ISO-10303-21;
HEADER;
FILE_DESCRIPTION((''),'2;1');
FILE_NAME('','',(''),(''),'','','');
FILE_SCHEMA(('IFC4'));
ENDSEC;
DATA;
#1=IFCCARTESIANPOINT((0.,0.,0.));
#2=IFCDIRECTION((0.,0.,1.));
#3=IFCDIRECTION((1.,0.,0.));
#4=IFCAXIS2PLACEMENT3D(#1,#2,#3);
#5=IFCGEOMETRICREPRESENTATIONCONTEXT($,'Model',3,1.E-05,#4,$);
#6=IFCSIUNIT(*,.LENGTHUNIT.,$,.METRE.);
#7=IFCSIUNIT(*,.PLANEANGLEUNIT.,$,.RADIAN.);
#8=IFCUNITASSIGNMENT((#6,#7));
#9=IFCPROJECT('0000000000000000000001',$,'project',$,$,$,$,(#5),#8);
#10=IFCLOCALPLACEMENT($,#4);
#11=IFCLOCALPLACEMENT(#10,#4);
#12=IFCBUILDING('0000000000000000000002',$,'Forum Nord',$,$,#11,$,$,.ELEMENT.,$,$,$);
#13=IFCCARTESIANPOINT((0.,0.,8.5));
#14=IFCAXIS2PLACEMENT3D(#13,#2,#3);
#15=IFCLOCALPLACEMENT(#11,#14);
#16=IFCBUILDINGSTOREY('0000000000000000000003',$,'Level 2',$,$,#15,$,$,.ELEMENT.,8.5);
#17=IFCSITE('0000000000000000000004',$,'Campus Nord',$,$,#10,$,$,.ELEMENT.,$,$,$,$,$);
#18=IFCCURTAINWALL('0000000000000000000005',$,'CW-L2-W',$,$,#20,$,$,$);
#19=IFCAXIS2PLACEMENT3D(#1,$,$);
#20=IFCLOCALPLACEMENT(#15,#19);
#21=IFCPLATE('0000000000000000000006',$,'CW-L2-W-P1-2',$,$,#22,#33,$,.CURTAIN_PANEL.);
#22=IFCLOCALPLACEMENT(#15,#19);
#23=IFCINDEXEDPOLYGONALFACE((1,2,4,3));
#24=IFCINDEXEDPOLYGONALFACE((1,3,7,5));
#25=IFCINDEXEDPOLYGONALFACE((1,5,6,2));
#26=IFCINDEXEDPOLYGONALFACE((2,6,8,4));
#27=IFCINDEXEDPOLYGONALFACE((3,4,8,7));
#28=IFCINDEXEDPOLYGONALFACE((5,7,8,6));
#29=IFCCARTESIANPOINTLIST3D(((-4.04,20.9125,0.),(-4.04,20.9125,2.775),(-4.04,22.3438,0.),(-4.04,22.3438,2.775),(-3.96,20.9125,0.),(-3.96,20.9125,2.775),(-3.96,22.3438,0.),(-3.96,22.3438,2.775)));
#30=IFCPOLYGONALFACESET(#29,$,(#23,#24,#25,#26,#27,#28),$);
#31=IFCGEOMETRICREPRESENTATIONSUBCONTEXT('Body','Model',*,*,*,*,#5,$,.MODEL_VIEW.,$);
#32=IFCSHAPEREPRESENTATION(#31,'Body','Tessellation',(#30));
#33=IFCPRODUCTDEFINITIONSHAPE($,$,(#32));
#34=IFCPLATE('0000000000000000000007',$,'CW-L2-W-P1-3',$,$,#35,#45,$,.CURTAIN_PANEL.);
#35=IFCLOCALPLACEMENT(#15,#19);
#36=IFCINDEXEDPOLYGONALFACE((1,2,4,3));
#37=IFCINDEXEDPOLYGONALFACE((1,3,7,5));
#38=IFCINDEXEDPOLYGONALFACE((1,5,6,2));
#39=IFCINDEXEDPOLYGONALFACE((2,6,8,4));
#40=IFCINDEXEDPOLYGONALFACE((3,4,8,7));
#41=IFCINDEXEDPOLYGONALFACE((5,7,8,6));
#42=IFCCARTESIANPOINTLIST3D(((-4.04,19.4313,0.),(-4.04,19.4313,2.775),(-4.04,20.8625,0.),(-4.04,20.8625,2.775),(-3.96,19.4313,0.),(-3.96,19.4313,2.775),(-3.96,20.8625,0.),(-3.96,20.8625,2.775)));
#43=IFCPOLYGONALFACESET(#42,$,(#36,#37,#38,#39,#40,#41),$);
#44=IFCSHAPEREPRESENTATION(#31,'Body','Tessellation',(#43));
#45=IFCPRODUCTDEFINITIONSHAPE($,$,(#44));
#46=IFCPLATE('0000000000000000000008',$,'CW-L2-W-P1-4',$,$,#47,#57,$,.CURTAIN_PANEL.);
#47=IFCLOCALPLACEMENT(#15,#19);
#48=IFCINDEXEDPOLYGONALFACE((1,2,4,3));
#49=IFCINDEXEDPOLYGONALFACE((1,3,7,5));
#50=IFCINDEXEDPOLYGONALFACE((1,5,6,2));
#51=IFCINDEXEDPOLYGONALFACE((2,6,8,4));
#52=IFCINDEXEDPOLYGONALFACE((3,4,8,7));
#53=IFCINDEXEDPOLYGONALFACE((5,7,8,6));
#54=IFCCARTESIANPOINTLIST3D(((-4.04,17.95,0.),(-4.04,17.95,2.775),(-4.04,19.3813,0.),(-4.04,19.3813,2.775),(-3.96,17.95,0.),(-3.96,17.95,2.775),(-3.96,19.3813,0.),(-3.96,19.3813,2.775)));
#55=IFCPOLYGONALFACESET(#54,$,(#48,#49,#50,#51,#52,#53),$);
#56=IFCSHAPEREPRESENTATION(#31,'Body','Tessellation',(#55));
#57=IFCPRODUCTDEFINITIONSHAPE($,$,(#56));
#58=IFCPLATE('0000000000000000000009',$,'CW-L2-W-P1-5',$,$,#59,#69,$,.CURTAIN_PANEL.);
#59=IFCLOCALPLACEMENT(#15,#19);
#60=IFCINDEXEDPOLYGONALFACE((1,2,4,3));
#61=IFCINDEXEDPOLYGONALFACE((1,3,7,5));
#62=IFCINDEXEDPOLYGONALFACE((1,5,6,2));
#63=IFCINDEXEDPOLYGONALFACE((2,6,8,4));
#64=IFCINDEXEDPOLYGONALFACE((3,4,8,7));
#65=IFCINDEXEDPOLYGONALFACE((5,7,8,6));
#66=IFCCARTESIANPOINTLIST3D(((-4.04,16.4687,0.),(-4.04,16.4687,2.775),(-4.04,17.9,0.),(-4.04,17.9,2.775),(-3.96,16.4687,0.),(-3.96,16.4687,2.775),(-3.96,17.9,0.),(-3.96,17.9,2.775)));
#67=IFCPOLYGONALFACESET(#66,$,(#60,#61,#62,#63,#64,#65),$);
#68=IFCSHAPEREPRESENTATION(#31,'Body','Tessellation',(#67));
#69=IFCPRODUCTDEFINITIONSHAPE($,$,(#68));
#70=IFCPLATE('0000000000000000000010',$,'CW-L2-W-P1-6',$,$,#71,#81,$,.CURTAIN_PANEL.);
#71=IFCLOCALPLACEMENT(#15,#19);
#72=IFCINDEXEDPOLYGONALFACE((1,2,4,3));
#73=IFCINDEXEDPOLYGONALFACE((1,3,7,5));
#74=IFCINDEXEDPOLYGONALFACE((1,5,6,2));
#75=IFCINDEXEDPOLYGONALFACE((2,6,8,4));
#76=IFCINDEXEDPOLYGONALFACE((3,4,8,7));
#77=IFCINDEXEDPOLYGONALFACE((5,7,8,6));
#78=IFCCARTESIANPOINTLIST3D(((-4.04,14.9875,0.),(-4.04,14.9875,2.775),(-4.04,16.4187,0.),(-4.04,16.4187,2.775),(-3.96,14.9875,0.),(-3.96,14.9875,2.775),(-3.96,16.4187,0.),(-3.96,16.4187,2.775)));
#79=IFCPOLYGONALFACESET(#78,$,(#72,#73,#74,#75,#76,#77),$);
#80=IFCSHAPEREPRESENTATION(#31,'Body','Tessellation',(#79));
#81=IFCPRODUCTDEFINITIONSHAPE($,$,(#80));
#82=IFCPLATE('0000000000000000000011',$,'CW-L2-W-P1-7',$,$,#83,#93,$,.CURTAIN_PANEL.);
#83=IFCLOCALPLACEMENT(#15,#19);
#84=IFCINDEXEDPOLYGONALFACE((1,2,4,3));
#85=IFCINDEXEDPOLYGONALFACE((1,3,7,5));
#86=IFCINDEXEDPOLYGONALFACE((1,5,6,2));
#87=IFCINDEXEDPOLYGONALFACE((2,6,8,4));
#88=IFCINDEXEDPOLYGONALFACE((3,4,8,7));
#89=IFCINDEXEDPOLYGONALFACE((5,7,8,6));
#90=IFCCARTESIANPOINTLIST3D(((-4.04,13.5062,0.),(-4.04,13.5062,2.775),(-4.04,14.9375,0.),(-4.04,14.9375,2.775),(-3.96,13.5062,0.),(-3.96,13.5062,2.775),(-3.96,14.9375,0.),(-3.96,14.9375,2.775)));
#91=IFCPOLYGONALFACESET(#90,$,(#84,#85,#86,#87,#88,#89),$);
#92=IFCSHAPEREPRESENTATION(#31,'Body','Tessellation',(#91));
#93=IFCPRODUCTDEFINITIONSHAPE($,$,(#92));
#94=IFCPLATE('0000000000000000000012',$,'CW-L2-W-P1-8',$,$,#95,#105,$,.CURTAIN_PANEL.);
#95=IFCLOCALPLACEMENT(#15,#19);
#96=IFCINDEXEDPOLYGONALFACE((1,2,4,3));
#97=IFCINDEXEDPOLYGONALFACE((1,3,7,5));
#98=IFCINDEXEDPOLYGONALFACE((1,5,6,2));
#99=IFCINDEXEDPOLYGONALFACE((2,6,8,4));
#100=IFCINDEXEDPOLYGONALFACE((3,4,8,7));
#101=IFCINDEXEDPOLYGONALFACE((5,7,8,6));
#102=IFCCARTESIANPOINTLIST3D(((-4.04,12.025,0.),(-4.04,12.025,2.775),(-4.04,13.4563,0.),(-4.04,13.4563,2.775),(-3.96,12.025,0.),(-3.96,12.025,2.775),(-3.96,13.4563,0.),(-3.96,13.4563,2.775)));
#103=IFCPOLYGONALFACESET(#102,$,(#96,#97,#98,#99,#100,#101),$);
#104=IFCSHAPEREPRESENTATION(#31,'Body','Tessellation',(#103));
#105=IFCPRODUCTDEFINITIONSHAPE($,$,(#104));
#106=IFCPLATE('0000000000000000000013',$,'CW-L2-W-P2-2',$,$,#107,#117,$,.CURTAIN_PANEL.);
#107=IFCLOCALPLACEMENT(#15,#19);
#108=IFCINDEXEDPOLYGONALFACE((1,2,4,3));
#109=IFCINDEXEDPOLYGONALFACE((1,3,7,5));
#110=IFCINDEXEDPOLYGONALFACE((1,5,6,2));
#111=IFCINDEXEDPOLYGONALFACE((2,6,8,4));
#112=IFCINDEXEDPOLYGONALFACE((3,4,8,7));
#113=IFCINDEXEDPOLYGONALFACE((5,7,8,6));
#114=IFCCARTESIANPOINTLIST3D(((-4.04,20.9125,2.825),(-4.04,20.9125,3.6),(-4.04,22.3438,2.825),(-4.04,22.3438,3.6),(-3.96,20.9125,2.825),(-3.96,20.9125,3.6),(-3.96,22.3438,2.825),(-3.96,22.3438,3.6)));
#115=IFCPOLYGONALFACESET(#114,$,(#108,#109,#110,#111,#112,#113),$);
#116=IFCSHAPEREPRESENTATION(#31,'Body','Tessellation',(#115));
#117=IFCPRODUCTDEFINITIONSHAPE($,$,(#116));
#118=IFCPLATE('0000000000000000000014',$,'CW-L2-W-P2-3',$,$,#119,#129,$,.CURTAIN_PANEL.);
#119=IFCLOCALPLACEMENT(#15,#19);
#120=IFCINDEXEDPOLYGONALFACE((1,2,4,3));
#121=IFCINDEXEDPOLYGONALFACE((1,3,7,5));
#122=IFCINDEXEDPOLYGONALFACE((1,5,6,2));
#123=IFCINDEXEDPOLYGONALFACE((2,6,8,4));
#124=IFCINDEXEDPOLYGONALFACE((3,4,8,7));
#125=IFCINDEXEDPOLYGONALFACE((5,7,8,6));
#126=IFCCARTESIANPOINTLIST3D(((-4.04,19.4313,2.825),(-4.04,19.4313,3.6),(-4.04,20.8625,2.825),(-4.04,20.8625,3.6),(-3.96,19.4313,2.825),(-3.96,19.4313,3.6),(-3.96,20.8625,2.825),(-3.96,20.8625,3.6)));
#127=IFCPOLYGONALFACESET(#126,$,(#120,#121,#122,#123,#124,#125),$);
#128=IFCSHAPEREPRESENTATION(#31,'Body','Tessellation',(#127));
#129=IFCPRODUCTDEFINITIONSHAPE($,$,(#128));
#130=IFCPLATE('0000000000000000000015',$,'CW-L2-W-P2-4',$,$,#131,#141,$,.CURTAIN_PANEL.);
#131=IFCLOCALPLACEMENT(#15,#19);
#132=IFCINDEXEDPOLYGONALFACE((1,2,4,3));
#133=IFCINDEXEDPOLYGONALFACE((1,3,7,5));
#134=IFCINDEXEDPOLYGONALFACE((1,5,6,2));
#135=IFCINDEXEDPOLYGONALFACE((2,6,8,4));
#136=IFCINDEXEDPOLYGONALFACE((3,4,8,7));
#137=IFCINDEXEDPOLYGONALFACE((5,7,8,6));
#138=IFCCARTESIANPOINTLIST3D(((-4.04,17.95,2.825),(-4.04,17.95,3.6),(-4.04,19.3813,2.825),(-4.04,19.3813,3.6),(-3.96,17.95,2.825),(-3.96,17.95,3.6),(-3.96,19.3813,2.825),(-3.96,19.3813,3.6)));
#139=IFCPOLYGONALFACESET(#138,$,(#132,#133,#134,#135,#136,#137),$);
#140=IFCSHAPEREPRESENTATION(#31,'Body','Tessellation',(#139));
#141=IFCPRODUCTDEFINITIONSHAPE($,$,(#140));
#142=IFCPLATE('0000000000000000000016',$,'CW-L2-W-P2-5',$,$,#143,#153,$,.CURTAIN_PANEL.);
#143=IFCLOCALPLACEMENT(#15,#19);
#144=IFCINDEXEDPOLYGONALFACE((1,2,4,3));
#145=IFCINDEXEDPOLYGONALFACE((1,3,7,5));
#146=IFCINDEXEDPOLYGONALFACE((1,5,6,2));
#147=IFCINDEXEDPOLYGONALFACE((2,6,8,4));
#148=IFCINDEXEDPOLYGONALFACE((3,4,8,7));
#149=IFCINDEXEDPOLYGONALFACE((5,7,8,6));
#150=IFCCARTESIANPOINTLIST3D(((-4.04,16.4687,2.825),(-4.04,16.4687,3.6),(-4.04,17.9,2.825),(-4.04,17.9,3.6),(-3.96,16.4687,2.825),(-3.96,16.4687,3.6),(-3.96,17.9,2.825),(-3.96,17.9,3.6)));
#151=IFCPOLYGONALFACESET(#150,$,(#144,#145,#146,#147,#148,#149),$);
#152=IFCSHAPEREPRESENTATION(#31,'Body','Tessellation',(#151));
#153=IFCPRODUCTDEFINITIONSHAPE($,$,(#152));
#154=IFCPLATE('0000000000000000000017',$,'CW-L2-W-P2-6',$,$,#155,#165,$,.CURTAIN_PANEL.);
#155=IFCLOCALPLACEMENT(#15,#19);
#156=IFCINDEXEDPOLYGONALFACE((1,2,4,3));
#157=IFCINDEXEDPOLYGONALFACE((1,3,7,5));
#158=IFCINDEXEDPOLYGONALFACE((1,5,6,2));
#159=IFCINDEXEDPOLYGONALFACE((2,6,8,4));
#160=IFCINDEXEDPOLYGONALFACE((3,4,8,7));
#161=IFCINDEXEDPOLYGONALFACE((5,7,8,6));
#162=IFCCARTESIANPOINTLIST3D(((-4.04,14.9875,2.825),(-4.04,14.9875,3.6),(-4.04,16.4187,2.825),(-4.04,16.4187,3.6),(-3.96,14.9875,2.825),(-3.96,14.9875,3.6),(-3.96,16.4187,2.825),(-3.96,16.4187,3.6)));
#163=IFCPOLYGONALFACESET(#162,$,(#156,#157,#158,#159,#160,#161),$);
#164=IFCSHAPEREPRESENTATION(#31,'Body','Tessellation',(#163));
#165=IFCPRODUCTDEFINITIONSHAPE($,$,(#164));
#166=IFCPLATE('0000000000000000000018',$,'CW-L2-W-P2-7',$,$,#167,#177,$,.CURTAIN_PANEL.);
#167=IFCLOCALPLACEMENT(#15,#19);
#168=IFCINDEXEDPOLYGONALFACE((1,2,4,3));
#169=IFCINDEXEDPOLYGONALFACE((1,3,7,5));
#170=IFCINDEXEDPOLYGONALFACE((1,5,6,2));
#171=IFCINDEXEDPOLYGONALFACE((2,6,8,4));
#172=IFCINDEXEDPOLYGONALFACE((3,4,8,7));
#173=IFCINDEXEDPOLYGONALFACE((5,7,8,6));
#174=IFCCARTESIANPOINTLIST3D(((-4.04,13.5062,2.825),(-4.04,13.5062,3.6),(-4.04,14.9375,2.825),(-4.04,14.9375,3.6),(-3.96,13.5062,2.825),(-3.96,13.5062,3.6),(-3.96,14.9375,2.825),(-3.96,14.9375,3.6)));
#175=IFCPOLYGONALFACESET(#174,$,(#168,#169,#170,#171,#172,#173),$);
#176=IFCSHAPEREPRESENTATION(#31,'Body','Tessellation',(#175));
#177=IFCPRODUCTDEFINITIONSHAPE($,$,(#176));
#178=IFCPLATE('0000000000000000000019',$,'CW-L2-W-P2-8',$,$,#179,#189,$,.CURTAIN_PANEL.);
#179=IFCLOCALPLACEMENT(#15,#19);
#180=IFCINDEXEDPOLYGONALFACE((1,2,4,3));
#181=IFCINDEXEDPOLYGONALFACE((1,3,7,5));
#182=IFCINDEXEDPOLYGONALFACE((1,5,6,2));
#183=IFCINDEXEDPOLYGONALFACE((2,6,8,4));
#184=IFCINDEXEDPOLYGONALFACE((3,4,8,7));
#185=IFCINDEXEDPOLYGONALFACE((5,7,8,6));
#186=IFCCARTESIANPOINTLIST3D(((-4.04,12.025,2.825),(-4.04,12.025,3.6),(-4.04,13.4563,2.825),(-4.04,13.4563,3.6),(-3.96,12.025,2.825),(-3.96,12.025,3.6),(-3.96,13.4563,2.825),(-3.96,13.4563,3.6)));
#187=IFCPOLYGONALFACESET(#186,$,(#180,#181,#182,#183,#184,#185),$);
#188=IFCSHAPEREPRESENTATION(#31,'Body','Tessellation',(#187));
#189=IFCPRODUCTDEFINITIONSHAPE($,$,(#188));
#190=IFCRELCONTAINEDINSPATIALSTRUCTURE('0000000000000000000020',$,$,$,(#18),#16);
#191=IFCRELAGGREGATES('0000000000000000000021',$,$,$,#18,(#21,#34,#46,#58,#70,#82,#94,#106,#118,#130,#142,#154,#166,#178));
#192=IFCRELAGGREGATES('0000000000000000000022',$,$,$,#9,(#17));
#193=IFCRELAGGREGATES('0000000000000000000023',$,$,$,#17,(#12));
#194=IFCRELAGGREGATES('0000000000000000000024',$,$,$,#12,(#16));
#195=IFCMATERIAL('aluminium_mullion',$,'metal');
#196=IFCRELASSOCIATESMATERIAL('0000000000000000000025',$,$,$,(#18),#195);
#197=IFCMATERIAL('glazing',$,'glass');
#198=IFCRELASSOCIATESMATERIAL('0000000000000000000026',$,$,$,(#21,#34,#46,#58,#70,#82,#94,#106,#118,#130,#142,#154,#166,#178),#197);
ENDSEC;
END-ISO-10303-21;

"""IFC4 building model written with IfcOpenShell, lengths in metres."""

from ifc_helpers import new_model, si_unit, frame, frame_2d, origin_with_axes, place, context, subcontext, project, spatial, rectangle, extrude, material, element, aggregate, save


model = new_model("IFC4")

# Units and contexts
model_context = context("Model", 3, precision=1e-05, world=origin_with_axes())
body_context = subcontext(model_context, "Body", "Model", "MODEL_VIEW")
ifc_project = project(units=[si_unit("LENGTHUNIT", "METRE"), si_unit("PLANEANGLEUNIT", "RADIAN")], contexts=[model_context])

# Site, building, storey
site_placement = place(None, origin_with_axes())
site = spatial("IfcSite", under=ifc_project, at=site_placement, Name="Campus Nord", CompositionType="ELEMENT")
building_placement = place(site_placement, origin_with_axes())
building = spatial("IfcBuilding", under=site, at=building_placement, Name="Forum Nord", CompositionType="ELEMENT")
storey_placement = place(building_placement, frame((0.0, 0.0, 8.5), z_axis=(0.0, 0.0, 1.0), x_axis=(1.0, 0.0, 0.0)))
storey = spatial("IfcBuildingStorey", under=building, at=storey_placement, Name="Level 2", CompositionType="ELEMENT", Elevation=8.5)

# Curtain wall, plates
ifc_material_1 = material(Name="aluminium_mullion", Category="metal")
curtain_wall_placement = place(storey_placement, origin_with_axes())
curtain_wall = element("IfcCurtainWall", 1, at=curtain_wall_placement, inside=storey, material=ifc_material_1, Name="CW-L2-W")
ifc_material_2 = material(Name="glazing", Category="glass")
plate_1_placement = place(storey_placement, frame((-4.0, 22.3438, 0.0), z_axis=(0.0, 0.0, 1.0), x_axis=(0.0, -1.0, 0.0)))
plate_1 = element("IfcPlate", 2, at=plate_1_placement, material=ifc_material_2, Name="CW-L2-W-P1-2", PredefinedType="CURTAIN_PANEL", context=body_context, shape_type="SweptSolid", body=[
    extrude(rectangle(XDim=1.4312, YDim=0.08, at=frame_2d((0.7156, 0.0), x_axis=(1.0, 0.0))), origin_with_axes(), (0.0, 0.0, 1.0), 2.775),
])
plate_2_placement = place(storey_placement, frame((-4.0, 20.8625, 0.0), z_axis=(0.0, 0.0, 1.0), x_axis=(0.0, -1.0, 0.0)))
plate_2 = element("IfcPlate", 3, at=plate_2_placement, material=ifc_material_2, Name="CW-L2-W-P1-3", PredefinedType="CURTAIN_PANEL", context=body_context, shape_type="SweptSolid", body=[
    extrude(rectangle(XDim=1.4312, YDim=0.08, at=frame_2d((0.7156, 0.0), x_axis=(1.0, 0.0))), origin_with_axes(), (0.0, 0.0, 1.0), 2.775),
])
plate_3_placement = place(storey_placement, frame((-4.0, 19.3813, 0.0), z_axis=(0.0, 0.0, 1.0), x_axis=(0.0, -1.0, 0.0)))
plate_3 = element("IfcPlate", 4, at=plate_3_placement, material=ifc_material_2, Name="CW-L2-W-P1-4", PredefinedType="CURTAIN_PANEL", context=body_context, shape_type="SweptSolid", body=[
    extrude(rectangle(XDim=1.4312, YDim=0.08, at=frame_2d((0.7156, 0.0), x_axis=(1.0, 0.0))), origin_with_axes(), (0.0, 0.0, 1.0), 2.775),
])
plate_4_placement = place(storey_placement, frame((-4.0, 17.9, 0.0), z_axis=(0.0, 0.0, 1.0), x_axis=(0.0, -1.0, 0.0)))
plate_4 = element("IfcPlate", 5, at=plate_4_placement, material=ifc_material_2, Name="CW-L2-W-P1-5", PredefinedType="CURTAIN_PANEL", context=body_context, shape_type="SweptSolid", body=[
    extrude(rectangle(XDim=1.4312, YDim=0.08, at=frame_2d((0.7156, 0.0), x_axis=(1.0, 0.0))), origin_with_axes(), (0.0, 0.0, 1.0), 2.775),
])
plate_5_placement = place(storey_placement, frame((-4.0, 16.4187, 0.0), z_axis=(0.0, 0.0, 1.0), x_axis=(0.0, -1.0, 0.0)))
plate_5 = element("IfcPlate", 6, at=plate_5_placement, material=ifc_material_2, Name="CW-L2-W-P1-6", PredefinedType="CURTAIN_PANEL", context=body_context, shape_type="SweptSolid", body=[
    extrude(rectangle(XDim=1.4312, YDim=0.08, at=frame_2d((0.7156, 0.0), x_axis=(1.0, 0.0))), origin_with_axes(), (0.0, 0.0, 1.0), 2.775),
])
plate_6_placement = place(storey_placement, frame((-4.0, 14.9375, 0.0), z_axis=(0.0, 0.0, 1.0), x_axis=(0.0, -1.0, 0.0)))
plate_6 = element("IfcPlate", 7, at=plate_6_placement, material=ifc_material_2, Name="CW-L2-W-P1-7", PredefinedType="CURTAIN_PANEL", context=body_context, shape_type="SweptSolid", body=[
    extrude(rectangle(XDim=1.4312, YDim=0.08, at=frame_2d((0.7156, 0.0), x_axis=(1.0, 0.0))), origin_with_axes(), (0.0, 0.0, 1.0), 2.775),
])
plate_7_placement = place(storey_placement, frame((-4.0, 13.4563, 0.0), z_axis=(0.0, 0.0, 1.0), x_axis=(0.0, -1.0, 0.0)))
plate_7 = element("IfcPlate", 8, at=plate_7_placement, material=ifc_material_2, Name="CW-L2-W-P1-8", PredefinedType="CURTAIN_PANEL", context=body_context, shape_type="SweptSolid", body=[
    extrude(rectangle(XDim=1.4312, YDim=0.08, at=frame_2d((0.7156, 0.0), x_axis=(1.0, 0.0))), origin_with_axes(), (0.0, 0.0, 1.0), 2.775),
])
plate_8_placement = place(storey_placement, frame((-4.0, 22.3438, 2.825), z_axis=(0.0, 0.0, 1.0), x_axis=(0.0, -1.0, 0.0)))
plate_8 = element("IfcPlate", 9, at=plate_8_placement, material=ifc_material_2, Name="CW-L2-W-P2-2", PredefinedType="CURTAIN_PANEL", context=body_context, shape_type="SweptSolid", body=[
    extrude(rectangle(XDim=1.4312, YDim=0.08, at=frame_2d((0.7156, 0.0), x_axis=(1.0, 0.0))), origin_with_axes(), (0.0, 0.0, 1.0), 0.775),
])
plate_9_placement = place(storey_placement, frame((-4.0, 20.8625, 2.825), z_axis=(0.0, 0.0, 1.0), x_axis=(0.0, -1.0, 0.0)))
plate_9 = element("IfcPlate", 10, at=plate_9_placement, material=ifc_material_2, Name="CW-L2-W-P2-3", PredefinedType="CURTAIN_PANEL", context=body_context, shape_type="SweptSolid", body=[
    extrude(rectangle(XDim=1.4312, YDim=0.08, at=frame_2d((0.7156, 0.0), x_axis=(1.0, 0.0))), origin_with_axes(), (0.0, 0.0, 1.0), 0.775),
])
plate_10_placement = place(storey_placement, frame((-4.0, 19.3813, 2.825), z_axis=(0.0, 0.0, 1.0), x_axis=(0.0, -1.0, 0.0)))
plate_10 = element("IfcPlate", 11, at=plate_10_placement, material=ifc_material_2, Name="CW-L2-W-P2-4", PredefinedType="CURTAIN_PANEL", context=body_context, shape_type="SweptSolid", body=[
    extrude(rectangle(XDim=1.4312, YDim=0.08, at=frame_2d((0.7156, 0.0), x_axis=(1.0, 0.0))), origin_with_axes(), (0.0, 0.0, 1.0), 0.775),
])
plate_11_placement = place(storey_placement, frame((-4.0, 17.9, 2.825), z_axis=(0.0, 0.0, 1.0), x_axis=(0.0, -1.0, 0.0)))
plate_11 = element("IfcPlate", 12, at=plate_11_placement, material=ifc_material_2, Name="CW-L2-W-P2-5", PredefinedType="CURTAIN_PANEL", context=body_context, shape_type="SweptSolid", body=[
    extrude(rectangle(XDim=1.4312, YDim=0.08, at=frame_2d((0.7156, 0.0), x_axis=(1.0, 0.0))), origin_with_axes(), (0.0, 0.0, 1.0), 0.775),
])
plate_12_placement = place(storey_placement, frame((-4.0, 16.4187, 2.825), z_axis=(0.0, 0.0, 1.0), x_axis=(0.0, -1.0, 0.0)))
plate_12 = element("IfcPlate", 13, at=plate_12_placement, material=ifc_material_2, Name="CW-L2-W-P2-6", PredefinedType="CURTAIN_PANEL", context=body_context, shape_type="SweptSolid", body=[
    extrude(rectangle(XDim=1.4312, YDim=0.08, at=frame_2d((0.7156, 0.0), x_axis=(1.0, 0.0))), origin_with_axes(), (0.0, 0.0, 1.0), 0.775),
])
plate_13_placement = place(storey_placement, frame((-4.0, 14.9375, 2.825), z_axis=(0.0, 0.0, 1.0), x_axis=(0.0, -1.0, 0.0)))
plate_13 = element("IfcPlate", 14, at=plate_13_placement, material=ifc_material_2, Name="CW-L2-W-P2-7", PredefinedType="CURTAIN_PANEL", context=body_context, shape_type="SweptSolid", body=[
    extrude(rectangle(XDim=1.4312, YDim=0.08, at=frame_2d((0.7156, 0.0), x_axis=(1.0, 0.0))), origin_with_axes(), (0.0, 0.0, 1.0), 0.775),
])
plate_14_placement = place(storey_placement, frame((-4.0, 13.4563, 2.825), z_axis=(0.0, 0.0, 1.0), x_axis=(0.0, -1.0, 0.0)))
plate_14 = element("IfcPlate", 15, at=plate_14_placement, material=ifc_material_2, Name="CW-L2-W-P2-8", PredefinedType="CURTAIN_PANEL", context=body_context, shape_type="SweptSolid", body=[
    extrude(rectangle(XDim=1.4312, YDim=0.08, at=frame_2d((0.7156, 0.0), x_axis=(1.0, 0.0))), origin_with_axes(), (0.0, 0.0, 1.0), 0.775),
])
aggregate(curtain_wall, [plate_1, plate_2, plate_3, plate_4, plate_5, plate_6, plate_7, plate_8, plate_9, plate_10, plate_11, plate_12, plate_13, plate_14])

save(model, "model.ifc")
